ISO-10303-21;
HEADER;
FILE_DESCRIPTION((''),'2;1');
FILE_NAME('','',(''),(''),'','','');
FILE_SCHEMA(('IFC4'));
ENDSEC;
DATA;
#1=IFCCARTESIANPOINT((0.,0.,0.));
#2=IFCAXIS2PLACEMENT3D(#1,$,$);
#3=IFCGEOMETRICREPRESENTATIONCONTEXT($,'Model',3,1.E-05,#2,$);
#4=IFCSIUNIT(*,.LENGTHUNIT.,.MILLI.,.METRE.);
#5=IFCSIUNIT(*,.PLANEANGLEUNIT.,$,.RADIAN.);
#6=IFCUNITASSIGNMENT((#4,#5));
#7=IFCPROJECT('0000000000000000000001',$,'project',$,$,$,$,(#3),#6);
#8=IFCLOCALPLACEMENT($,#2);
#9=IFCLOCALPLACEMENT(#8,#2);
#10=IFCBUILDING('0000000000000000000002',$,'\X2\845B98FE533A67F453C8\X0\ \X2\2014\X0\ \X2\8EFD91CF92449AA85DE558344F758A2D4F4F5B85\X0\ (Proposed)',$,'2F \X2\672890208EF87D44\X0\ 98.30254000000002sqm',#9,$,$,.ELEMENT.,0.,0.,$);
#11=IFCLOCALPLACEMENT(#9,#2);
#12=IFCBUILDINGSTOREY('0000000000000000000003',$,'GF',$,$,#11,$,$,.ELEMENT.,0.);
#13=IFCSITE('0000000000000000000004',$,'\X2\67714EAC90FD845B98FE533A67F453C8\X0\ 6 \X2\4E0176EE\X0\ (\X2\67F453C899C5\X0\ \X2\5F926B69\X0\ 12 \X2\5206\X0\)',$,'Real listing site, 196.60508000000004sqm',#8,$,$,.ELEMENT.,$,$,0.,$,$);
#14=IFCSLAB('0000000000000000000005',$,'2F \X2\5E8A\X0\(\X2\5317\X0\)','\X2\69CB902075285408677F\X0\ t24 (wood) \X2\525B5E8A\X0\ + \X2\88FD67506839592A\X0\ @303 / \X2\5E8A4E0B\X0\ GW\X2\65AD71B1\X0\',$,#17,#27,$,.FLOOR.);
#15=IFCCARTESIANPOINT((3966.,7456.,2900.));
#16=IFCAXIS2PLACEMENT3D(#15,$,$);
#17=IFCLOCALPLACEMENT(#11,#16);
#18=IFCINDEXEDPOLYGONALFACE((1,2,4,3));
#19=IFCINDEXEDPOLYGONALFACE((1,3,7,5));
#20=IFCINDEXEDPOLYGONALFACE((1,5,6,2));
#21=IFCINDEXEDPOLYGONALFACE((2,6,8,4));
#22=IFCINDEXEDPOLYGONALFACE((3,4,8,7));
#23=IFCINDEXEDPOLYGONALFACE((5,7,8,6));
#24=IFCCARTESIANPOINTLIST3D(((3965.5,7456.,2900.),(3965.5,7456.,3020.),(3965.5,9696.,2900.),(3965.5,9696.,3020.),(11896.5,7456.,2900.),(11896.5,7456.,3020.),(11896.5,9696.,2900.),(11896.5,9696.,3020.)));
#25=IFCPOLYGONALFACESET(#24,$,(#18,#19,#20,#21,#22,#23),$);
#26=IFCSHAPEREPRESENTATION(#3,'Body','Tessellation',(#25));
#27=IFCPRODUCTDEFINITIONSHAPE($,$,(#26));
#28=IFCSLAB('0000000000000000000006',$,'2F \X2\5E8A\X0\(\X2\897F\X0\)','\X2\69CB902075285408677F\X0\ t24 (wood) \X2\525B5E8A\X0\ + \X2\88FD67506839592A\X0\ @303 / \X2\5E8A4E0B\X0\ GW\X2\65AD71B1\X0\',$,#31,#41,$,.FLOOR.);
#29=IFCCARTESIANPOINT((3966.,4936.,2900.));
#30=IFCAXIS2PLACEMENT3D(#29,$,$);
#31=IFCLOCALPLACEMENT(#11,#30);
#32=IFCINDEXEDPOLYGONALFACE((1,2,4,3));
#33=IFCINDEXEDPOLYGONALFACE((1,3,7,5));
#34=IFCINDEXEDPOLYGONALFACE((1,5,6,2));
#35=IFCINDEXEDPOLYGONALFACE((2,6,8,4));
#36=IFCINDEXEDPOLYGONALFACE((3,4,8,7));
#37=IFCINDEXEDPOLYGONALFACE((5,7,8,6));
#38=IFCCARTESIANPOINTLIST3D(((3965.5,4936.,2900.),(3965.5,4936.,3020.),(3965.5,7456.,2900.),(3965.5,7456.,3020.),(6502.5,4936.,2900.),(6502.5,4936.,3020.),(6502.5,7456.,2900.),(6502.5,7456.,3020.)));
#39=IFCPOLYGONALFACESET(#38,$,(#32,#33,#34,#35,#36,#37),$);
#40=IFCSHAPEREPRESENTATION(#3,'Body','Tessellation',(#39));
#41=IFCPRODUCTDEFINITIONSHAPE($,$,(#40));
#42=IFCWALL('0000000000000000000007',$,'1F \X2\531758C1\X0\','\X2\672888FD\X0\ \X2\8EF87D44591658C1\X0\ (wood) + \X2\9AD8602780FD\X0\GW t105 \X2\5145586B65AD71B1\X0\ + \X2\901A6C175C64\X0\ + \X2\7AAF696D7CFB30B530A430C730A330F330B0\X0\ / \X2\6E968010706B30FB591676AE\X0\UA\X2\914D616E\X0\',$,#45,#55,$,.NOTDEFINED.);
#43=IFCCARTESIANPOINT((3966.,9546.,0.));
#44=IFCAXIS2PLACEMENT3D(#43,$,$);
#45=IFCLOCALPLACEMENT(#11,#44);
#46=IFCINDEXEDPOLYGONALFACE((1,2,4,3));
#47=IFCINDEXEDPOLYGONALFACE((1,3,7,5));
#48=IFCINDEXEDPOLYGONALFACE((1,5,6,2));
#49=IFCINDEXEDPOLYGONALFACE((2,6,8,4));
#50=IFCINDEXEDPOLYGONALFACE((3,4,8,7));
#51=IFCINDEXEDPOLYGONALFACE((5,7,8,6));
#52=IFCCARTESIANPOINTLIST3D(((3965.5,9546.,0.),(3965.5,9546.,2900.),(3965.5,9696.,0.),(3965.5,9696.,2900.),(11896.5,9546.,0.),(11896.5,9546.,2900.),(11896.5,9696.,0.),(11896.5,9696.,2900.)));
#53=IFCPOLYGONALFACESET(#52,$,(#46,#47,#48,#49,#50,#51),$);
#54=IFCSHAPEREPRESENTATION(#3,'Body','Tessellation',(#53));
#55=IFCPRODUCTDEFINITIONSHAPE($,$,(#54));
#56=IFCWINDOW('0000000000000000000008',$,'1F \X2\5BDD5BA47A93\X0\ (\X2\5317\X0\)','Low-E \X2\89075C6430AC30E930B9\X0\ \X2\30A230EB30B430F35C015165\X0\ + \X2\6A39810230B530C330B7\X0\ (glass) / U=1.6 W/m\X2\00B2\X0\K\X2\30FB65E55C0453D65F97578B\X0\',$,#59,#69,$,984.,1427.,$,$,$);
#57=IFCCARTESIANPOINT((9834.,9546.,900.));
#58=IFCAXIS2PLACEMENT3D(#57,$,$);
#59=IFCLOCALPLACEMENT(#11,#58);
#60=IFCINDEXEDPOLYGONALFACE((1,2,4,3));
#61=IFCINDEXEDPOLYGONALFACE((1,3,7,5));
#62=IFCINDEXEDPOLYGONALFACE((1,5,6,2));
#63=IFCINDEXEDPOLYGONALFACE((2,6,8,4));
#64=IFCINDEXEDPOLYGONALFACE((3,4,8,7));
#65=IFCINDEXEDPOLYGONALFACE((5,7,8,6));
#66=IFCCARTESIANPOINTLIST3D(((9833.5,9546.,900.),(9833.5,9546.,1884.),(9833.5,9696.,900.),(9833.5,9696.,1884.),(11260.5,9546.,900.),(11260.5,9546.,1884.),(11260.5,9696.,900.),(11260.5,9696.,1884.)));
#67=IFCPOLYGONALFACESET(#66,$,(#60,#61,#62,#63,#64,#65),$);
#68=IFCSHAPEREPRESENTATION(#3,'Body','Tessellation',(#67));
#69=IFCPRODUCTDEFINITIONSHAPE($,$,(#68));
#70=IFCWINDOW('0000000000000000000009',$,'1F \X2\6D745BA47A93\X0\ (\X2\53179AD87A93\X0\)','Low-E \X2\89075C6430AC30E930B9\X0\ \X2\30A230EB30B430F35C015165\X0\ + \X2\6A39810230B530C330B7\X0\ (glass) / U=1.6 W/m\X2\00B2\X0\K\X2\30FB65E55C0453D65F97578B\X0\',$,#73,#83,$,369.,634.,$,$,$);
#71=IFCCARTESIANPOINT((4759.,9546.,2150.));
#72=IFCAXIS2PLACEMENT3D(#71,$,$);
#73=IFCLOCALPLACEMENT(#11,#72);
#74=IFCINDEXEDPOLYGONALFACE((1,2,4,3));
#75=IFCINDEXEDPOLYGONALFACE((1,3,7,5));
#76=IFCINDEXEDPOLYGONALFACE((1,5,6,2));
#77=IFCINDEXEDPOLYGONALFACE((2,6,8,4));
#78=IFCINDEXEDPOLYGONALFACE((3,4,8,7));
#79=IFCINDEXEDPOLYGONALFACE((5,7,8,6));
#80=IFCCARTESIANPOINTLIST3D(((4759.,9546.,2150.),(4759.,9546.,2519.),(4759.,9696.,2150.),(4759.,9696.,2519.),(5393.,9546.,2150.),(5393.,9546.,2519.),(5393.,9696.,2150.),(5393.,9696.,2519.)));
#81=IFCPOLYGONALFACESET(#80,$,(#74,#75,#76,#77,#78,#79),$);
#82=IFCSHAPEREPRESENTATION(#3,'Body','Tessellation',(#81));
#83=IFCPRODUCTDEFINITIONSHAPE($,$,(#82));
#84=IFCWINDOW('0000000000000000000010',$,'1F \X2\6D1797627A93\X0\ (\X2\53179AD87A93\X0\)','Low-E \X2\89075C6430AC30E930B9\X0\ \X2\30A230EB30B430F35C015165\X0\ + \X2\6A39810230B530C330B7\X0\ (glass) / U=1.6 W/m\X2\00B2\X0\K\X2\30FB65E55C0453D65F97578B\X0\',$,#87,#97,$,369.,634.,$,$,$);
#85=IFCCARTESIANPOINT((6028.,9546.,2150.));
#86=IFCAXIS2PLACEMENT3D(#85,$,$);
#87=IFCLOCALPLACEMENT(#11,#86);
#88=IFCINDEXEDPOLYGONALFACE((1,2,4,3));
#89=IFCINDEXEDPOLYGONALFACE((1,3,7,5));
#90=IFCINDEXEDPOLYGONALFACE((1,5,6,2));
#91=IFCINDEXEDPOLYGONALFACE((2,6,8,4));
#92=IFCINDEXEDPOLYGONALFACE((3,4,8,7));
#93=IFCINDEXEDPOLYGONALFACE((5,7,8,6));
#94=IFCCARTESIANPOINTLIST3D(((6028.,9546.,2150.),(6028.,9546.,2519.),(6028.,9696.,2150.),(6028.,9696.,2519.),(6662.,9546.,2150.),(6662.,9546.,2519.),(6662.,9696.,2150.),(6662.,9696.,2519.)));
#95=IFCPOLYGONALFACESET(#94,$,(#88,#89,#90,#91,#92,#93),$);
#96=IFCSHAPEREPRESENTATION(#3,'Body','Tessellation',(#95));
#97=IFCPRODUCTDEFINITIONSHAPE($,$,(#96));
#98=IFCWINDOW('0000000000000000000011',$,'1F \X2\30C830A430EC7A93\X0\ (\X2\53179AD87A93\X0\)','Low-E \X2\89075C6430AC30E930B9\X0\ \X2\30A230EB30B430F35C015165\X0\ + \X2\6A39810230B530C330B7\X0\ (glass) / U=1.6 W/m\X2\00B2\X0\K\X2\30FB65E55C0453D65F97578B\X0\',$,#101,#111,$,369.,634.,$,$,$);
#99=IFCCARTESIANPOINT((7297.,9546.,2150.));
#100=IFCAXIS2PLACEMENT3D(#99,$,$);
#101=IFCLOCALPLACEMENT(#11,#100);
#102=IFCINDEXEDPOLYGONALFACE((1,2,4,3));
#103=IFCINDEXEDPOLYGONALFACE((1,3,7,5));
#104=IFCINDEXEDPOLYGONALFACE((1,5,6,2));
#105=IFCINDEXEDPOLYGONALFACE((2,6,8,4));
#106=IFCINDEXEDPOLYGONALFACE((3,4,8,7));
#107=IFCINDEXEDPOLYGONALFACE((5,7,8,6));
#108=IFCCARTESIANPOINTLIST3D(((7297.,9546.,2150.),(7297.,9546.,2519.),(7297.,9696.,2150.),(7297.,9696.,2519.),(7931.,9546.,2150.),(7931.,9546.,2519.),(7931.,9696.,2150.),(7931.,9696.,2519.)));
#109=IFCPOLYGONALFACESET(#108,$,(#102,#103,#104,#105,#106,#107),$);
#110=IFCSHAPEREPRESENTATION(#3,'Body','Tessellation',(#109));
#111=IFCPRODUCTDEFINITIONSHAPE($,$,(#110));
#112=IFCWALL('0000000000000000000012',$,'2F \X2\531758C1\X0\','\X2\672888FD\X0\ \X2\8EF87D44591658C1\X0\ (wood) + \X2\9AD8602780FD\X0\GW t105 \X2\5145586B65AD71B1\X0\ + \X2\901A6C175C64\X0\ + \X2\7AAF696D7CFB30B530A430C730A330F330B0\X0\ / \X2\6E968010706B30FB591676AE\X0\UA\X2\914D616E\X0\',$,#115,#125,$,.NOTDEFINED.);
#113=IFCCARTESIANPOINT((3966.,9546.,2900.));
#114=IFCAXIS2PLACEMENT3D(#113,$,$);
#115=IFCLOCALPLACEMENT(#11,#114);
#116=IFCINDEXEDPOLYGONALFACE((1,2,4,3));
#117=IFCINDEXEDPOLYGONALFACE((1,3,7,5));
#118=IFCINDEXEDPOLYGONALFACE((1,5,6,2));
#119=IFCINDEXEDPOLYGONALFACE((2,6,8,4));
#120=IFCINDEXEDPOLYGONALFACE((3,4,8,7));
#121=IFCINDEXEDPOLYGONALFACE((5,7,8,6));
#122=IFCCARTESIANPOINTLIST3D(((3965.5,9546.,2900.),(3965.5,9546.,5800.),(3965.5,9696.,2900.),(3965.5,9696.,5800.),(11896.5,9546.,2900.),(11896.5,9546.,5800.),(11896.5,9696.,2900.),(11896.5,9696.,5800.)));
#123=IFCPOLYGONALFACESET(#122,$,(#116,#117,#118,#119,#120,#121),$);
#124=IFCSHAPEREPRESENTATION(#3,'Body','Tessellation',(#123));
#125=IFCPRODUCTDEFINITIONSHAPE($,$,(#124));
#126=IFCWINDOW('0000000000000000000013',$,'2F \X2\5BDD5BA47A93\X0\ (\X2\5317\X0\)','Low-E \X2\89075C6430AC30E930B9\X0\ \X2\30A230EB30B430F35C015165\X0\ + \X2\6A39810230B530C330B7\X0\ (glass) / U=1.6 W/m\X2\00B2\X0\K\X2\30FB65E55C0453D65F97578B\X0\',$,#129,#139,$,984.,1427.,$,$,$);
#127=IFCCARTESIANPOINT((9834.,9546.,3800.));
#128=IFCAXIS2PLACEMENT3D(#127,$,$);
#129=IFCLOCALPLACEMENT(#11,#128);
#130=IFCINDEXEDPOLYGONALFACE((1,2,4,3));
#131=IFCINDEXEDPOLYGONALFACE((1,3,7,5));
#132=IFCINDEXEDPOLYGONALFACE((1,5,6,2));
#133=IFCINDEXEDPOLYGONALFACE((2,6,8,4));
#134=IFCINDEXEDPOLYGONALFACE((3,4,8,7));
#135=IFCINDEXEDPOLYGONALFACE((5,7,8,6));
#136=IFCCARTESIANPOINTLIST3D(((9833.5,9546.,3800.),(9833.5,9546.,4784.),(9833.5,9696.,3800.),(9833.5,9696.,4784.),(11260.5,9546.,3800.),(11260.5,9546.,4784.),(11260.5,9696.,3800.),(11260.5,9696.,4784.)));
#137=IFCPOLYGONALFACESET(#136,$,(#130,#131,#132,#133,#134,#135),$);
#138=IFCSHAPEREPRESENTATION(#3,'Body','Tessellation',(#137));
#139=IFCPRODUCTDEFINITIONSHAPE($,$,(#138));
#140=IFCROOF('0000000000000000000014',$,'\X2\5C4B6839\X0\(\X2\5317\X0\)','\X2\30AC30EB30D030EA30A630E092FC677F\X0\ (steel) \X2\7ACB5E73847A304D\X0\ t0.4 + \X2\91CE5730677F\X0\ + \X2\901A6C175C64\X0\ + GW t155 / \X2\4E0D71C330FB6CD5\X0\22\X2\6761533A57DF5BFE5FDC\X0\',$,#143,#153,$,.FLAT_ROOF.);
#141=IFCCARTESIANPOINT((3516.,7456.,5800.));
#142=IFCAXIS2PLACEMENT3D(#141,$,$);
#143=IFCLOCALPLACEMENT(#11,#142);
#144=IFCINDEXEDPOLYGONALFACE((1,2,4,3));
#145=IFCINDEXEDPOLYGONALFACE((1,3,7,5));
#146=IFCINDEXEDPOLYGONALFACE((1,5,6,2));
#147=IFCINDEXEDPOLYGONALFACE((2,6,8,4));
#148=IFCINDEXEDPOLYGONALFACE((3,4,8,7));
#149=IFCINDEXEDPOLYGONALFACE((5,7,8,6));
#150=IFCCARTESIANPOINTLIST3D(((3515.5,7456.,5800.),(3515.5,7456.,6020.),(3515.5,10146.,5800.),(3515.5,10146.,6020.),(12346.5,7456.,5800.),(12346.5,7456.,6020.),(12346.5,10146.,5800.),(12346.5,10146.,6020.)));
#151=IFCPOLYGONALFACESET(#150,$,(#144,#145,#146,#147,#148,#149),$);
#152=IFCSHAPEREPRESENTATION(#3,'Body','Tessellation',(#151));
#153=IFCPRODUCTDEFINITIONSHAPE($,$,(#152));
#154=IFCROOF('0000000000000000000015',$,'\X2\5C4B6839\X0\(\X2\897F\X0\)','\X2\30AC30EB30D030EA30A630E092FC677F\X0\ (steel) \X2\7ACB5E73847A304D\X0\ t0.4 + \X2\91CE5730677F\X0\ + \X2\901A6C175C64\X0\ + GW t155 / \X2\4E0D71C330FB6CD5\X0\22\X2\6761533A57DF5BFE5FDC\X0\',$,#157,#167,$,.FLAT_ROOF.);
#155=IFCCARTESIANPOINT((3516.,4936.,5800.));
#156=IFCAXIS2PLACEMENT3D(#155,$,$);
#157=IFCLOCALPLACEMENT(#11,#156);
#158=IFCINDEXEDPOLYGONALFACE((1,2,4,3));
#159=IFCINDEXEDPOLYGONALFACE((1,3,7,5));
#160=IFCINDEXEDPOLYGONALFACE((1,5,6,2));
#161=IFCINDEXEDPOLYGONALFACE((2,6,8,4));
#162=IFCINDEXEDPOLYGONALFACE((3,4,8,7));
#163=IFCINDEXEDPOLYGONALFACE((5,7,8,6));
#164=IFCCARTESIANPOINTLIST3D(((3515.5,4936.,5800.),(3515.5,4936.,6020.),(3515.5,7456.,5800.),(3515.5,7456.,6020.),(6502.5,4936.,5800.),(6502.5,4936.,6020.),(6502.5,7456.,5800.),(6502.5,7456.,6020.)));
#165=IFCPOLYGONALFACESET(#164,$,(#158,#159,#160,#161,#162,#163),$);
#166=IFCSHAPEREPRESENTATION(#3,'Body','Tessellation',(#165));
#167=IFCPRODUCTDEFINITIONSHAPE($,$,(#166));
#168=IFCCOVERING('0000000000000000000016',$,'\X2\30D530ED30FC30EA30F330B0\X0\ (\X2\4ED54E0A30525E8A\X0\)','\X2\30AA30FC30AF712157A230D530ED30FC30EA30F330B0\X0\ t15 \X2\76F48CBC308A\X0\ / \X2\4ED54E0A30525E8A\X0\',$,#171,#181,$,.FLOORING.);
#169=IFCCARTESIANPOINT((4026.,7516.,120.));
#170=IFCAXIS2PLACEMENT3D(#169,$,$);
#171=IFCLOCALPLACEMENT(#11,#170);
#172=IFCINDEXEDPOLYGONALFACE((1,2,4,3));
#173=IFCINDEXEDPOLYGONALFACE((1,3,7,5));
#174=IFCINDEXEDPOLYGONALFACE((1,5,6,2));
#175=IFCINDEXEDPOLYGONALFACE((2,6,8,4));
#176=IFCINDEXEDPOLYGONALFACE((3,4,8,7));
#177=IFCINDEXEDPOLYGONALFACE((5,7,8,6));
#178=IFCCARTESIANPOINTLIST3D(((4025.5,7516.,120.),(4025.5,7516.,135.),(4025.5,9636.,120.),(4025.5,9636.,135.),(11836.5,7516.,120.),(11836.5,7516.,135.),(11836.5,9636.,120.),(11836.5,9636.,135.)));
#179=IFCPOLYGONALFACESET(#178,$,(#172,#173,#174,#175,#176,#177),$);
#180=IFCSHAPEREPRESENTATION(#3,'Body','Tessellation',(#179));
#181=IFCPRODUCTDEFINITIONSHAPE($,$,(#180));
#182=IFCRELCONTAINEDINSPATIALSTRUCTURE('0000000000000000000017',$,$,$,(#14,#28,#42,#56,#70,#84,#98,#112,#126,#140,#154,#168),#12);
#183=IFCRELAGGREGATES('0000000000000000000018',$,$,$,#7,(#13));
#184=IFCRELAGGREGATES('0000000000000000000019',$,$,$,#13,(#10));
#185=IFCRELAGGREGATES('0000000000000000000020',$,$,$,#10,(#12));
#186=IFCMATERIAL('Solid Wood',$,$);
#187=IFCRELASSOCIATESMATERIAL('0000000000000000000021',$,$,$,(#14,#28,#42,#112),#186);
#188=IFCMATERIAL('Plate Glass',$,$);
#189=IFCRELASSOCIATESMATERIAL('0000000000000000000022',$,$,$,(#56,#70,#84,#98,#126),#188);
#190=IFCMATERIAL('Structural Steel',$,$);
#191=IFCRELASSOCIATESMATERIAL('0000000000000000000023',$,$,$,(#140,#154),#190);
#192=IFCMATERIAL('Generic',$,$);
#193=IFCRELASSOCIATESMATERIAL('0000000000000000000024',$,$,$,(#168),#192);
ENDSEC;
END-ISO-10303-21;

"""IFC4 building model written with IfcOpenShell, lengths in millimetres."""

from ifc_helpers import new_model, si_unit, frame, frame_2d, origin, place, context, project, spatial, rectangle, extrude, material, element, fill, save


model = new_model("IFC4")

# Units and contexts
model_context = context("Model", 3, precision=1e-05, world=origin())
ifc_project = project(units=[si_unit("LENGTHUNIT", "METRE", prefix="MILLI"), si_unit("PLANEANGLEUNIT", "RADIAN")], contexts=[model_context])

# Site, building, storey
site_placement = place(None, origin())
site = spatial("IfcSite", under=ifc_project, at=site_placement, Name="東京都葛飾区柴又 6 丁目 (柴又駅 徒歩 12 分)", ObjectType="Real listing site, 196.60508000000004sqm", CompositionType="ELEMENT", RefElevation=0.0)
building_placement = place(site_placement, origin())
building = spatial("IfcBuilding", under=site, at=building_placement, Name="葛飾区柴又 — 軽量鉄骨工場併設住宅 (Proposed)", ObjectType="2F 木造軸組 98.30254000000002sqm", CompositionType="ELEMENT", ElevationOfRefHeight=0.0, ElevationOfTerrain=0.0)
storey_placement = place(building_placement, origin())
storey = spatial("IfcBuildingStorey", under=building, at=storey_placement, Name="GF", CompositionType="ELEMENT", Elevation=0.0)

# Slabs
ifc_material_1 = material(Name="Solid Wood")
slab_1_placement = place(storey_placement, frame((3966.0, 7456.0, 2900.0)))
element("IfcSlab", 1, at=slab_1_placement, inside=storey, material=ifc_material_1, Name="2F 床(北)", Description="構造用合板 t24 (wood) 剛床 + 製材根太 @303 / 床下 GW断熱", PredefinedType="FLOOR", context=model_context, shape_type="SweptSolid", body=[
    extrude(rectangle(XDim=7931.0, YDim=2240.0, at=frame_2d((3965.0, 1120.0))), frame((3966.0, 7456.0, 2900.0)), (0.0, 0.0, 1.0), 120.0),
])
slab_2_placement = place(storey_placement, frame((3966.0, 4936.0, 2900.0)))
element("IfcSlab", 2, at=slab_2_placement, inside=storey, material=ifc_material_1, Name="2F 床(西)", Description="構造用合板 t24 (wood) 剛床 + 製材根太 @303 / 床下 GW断熱", PredefinedType="FLOOR", context=model_context, shape_type="SweptSolid", body=[
    extrude(rectangle(XDim=2537.0, YDim=2520.0, at=frame_2d((1268.0, 1260.0))), frame((3966.0, 4936.0, 2900.0)), (0.0, 0.0, 1.0), 120.0),
])

# Wall, openings, windows
wall_1_placement = place(storey_placement, frame((3966.0, 9546.0, 0.0)))
wall_1 = element("IfcWall", 3, at=wall_1_placement, inside=storey, material=ifc_material_1, Name="1F 北壁", Description="木製 軸組外壁 (wood) + 高性能GW t105 充填断熱 + 通気層 + 窯業系サイディング / 準耐火・外皮UA配慮", PredefinedType="NOTDEFINED", context=model_context, shape_type="SweptSolid", body=[
    extrude(rectangle(XDim=7931.0, YDim=150.0, at=frame_2d((3965.0, 75.0))), frame((3966.0, 9546.0, 0.0)), (0.0, 0.0, 1.0), 2900.0),
])
opening_1_placement = place(storey_placement, frame((9834.0, 9546.0, 900.0)))
opening_1 = element("IfcOpeningElement", 4, at=opening_1_placement, cuts=wall_1, PredefinedType="NOTDEFINED", context=model_context, shape_type="SweptSolid", body=[
    extrude(rectangle(XDim=1427.0, YDim=150.0, at=frame_2d((713.0, 75.0))), frame((9834.0, 9546.0, 900.0)), (0.0, 0.0, 1.0), 984.0),
])
opening_2_placement = place(storey_placement, frame((4759.0, 9546.0, 2150.0)))
opening_2 = element("IfcOpeningElement", 5, at=opening_2_placement, cuts=wall_1, PredefinedType="NOTDEFINED", context=model_context, shape_type="SweptSolid", body=[
    extrude(rectangle(XDim=634.0, YDim=150.0, at=frame_2d((317.0, 75.0))), frame((4759.0, 9546.0, 2150.0)), (0.0, 0.0, 1.0), 369.0),
])
opening_3_placement = place(storey_placement, frame((6028.0, 9546.0, 2150.0)))
opening_3 = element("IfcOpeningElement", 6, at=opening_3_placement, cuts=wall_1, PredefinedType="NOTDEFINED", context=model_context, shape_type="SweptSolid", body=[
    extrude(rectangle(XDim=634.0, YDim=150.0, at=frame_2d((317.0, 75.0))), frame((6028.0, 9546.0, 2150.0)), (0.0, 0.0, 1.0), 369.0),
])
opening_4_placement = place(storey_placement, frame((7297.0, 9546.0, 2150.0)))
opening_4 = element("IfcOpeningElement", 7, at=opening_4_placement, cuts=wall_1, PredefinedType="NOTDEFINED", context=model_context, shape_type="SweptSolid", body=[
    extrude(rectangle(XDim=634.0, YDim=150.0, at=frame_2d((317.0, 75.0))), frame((7297.0, 9546.0, 2150.0)), (0.0, 0.0, 1.0), 369.0),
])
ifc_material_2 = material(Name="Plate Glass")
window_1_placement = place(storey_placement, frame((9834.0, 9546.0, 900.0)))
window_1 = element("IfcWindow", 8, at=window_1_placement, inside=storey, material=ifc_material_2, Name="1F 寝室窓 (北)", Description="Low-E 複層ガラス アルゴン封入 + 樹脂サッシ (glass) / U=1.6 W/m²K・日射取得型", OverallHeight=984.0, OverallWidth=1427.0, context=model_context, shape_type="SweptSolid", body=[
    extrude(rectangle(XDim=1427.0, YDim=150.0, at=frame_2d((713.0, 75.0))), frame((9834.0, 9546.0, 900.0)), (0.0, 0.0, 1.0), 984.0),
])
fill(opening_1, window_1)
window_2_placement = place(storey_placement, frame((4759.0, 9546.0, 2150.0)))
window_2 = element("IfcWindow", 9, at=window_2_placement, inside=storey, material=ifc_material_2, Name="1F 浴室窓 (北高窓)", Description="Low-E 複層ガラス アルゴン封入 + 樹脂サッシ (glass) / U=1.6 W/m²K・日射取得型", OverallHeight=369.0, OverallWidth=634.0, context=model_context, shape_type="SweptSolid", body=[
    extrude(rectangle(XDim=634.0, YDim=150.0, at=frame_2d((317.0, 75.0))), frame((4759.0, 9546.0, 2150.0)), (0.0, 0.0, 1.0), 369.0),
])
fill(opening_2, window_2)
window_3_placement = place(storey_placement, frame((6028.0, 9546.0, 2150.0)))
window_3 = element("IfcWindow", 10, at=window_3_placement, inside=storey, material=ifc_material_2, Name="1F 洗面窓 (北高窓)", Description="Low-E 複層ガラス アルゴン封入 + 樹脂サッシ (glass) / U=1.6 W/m²K・日射取得型", OverallHeight=369.0, OverallWidth=634.0, context=model_context, shape_type="SweptSolid", body=[
    extrude(rectangle(XDim=634.0, YDim=150.0, at=frame_2d((317.0, 75.0))), frame((6028.0, 9546.0, 2150.0)), (0.0, 0.0, 1.0), 369.0),
])
fill(opening_3, window_3)
window_4_placement = place(storey_placement, frame((7297.0, 9546.0, 2150.0)))
window_4 = element("IfcWindow", 11, at=window_4_placement, inside=storey, material=ifc_material_2, Name="1F トイレ窓 (北高窓)", Description="Low-E 複層ガラス アルゴン封入 + 樹脂サッシ (glass) / U=1.6 W/m²K・日射取得型", OverallHeight=369.0, OverallWidth=634.0, context=model_context, shape_type="SweptSolid", body=[
    extrude(rectangle(XDim=634.0, YDim=150.0, at=frame_2d((317.0, 75.0))), frame((7297.0, 9546.0, 2150.0)), (0.0, 0.0, 1.0), 369.0),
])
fill(opening_4, window_4)

# Wall, opening, window
wall_2_placement = place(storey_placement, frame((3966.0, 9546.0, 2900.0)))
wall_2 = element("IfcWall", 12, at=wall_2_placement, inside=storey, material=ifc_material_1, Name="2F 北壁", Description="木製 軸組外壁 (wood) + 高性能GW t105 充填断熱 + 通気層 + 窯業系サイディング / 準耐火・外皮UA配慮", PredefinedType="NOTDEFINED", context=model_context, shape_type="SweptSolid", body=[
    extrude(rectangle(XDim=7931.0, YDim=150.0, at=frame_2d((3965.0, 75.0))), frame((3966.0, 9546.0, 2900.0)), (0.0, 0.0, 1.0), 2900.0),
])
opening_5_placement = place(storey_placement, frame((9834.0, 9546.0, 3800.0)))
opening_5 = element("IfcOpeningElement", 13, at=opening_5_placement, cuts=wall_2, PredefinedType="NOTDEFINED", context=model_context, shape_type="SweptSolid", body=[
    extrude(rectangle(XDim=1427.0, YDim=150.0, at=frame_2d((713.0, 75.0))), frame((9834.0, 9546.0, 3800.0)), (0.0, 0.0, 1.0), 984.0),
])
window_5_placement = place(storey_placement, frame((9834.0, 9546.0, 3800.0)))
window_5 = element("IfcWindow", 14, at=window_5_placement, inside=storey, material=ifc_material_2, Name="2F 寝室窓 (北)", Description="Low-E 複層ガラス アルゴン封入 + 樹脂サッシ (glass) / U=1.6 W/m²K・日射取得型", OverallHeight=984.0, OverallWidth=1427.0, context=model_context, shape_type="SweptSolid", body=[
    extrude(rectangle(XDim=1427.0, YDim=150.0, at=frame_2d((713.0, 75.0))), frame((9834.0, 9546.0, 3800.0)), (0.0, 0.0, 1.0), 984.0),
])
fill(opening_5, window_5)

# Roofs
ifc_material_3 = material(Name="Structural Steel")
for number, where, name in (
    (15, (3516.0, 7456.0, 5800.0), "屋根(北)"),
):
    element("IfcRoof", number, at=place(storey_placement, frame(where)), inside=storey, material=ifc_material_3, Name=name, Description="ガルバリウム鋼板 (steel) 立平葺き t0.4 + 野地板 + 通気層 + GW t155 / 不燃・法22条区域対応", PredefinedType="FLAT_ROOF", context=model_context, shape_type="SweptSolid", body=[
        extrude(rectangle(XDim=8831.0, YDim=2690.0, at=frame_2d((4415.0, 1345.0))), frame((3516.0, 7456.0, 5800.0)), (0.0, 0.0, 1.0), 220.0),
    ])
roof_placement = place(storey_placement, frame((3516.0, 4936.0, 5800.0)))
element("IfcRoof", 16, at=roof_placement, inside=storey, material=ifc_material_3, Name="屋根(西)", Description="ガルバリウム鋼板 (steel) 立平葺き t0.4 + 野地板 + 通気層 + GW t155 / 不燃・法22条区域対応", PredefinedType="FLAT_ROOF", context=model_context, shape_type="SweptSolid", body=[
    extrude(rectangle(XDim=2987.0, YDim=2520.0, at=frame_2d((1493.0, 1260.0))), frame((3516.0, 4936.0, 5800.0)), (0.0, 0.0, 1.0), 220.0),
])

# Covering
ifc_material_4 = material(Name="Generic")
covering_1_placement = place(storey_placement, frame((4026.0, 7516.0, 120.0)))
element("IfcCovering", 17, at=covering_1_placement, inside=storey, material=ifc_material_4, Name="フローリング (仕上げ床)", Description="オーク無垢フローリング t15 直貼り / 仕上げ床", PredefinedType="FLOORING", context=model_context, shape_type="SweptSolid", body=[
    extrude(rectangle(XDim=7811.0, YDim=2120.0, at=frame_2d((3905.0, 1060.0))), frame((4026.0, 7516.0, 120.0)), (0.0, 0.0, 1.0), 15.0),
])

save(model, "model.ifc")
